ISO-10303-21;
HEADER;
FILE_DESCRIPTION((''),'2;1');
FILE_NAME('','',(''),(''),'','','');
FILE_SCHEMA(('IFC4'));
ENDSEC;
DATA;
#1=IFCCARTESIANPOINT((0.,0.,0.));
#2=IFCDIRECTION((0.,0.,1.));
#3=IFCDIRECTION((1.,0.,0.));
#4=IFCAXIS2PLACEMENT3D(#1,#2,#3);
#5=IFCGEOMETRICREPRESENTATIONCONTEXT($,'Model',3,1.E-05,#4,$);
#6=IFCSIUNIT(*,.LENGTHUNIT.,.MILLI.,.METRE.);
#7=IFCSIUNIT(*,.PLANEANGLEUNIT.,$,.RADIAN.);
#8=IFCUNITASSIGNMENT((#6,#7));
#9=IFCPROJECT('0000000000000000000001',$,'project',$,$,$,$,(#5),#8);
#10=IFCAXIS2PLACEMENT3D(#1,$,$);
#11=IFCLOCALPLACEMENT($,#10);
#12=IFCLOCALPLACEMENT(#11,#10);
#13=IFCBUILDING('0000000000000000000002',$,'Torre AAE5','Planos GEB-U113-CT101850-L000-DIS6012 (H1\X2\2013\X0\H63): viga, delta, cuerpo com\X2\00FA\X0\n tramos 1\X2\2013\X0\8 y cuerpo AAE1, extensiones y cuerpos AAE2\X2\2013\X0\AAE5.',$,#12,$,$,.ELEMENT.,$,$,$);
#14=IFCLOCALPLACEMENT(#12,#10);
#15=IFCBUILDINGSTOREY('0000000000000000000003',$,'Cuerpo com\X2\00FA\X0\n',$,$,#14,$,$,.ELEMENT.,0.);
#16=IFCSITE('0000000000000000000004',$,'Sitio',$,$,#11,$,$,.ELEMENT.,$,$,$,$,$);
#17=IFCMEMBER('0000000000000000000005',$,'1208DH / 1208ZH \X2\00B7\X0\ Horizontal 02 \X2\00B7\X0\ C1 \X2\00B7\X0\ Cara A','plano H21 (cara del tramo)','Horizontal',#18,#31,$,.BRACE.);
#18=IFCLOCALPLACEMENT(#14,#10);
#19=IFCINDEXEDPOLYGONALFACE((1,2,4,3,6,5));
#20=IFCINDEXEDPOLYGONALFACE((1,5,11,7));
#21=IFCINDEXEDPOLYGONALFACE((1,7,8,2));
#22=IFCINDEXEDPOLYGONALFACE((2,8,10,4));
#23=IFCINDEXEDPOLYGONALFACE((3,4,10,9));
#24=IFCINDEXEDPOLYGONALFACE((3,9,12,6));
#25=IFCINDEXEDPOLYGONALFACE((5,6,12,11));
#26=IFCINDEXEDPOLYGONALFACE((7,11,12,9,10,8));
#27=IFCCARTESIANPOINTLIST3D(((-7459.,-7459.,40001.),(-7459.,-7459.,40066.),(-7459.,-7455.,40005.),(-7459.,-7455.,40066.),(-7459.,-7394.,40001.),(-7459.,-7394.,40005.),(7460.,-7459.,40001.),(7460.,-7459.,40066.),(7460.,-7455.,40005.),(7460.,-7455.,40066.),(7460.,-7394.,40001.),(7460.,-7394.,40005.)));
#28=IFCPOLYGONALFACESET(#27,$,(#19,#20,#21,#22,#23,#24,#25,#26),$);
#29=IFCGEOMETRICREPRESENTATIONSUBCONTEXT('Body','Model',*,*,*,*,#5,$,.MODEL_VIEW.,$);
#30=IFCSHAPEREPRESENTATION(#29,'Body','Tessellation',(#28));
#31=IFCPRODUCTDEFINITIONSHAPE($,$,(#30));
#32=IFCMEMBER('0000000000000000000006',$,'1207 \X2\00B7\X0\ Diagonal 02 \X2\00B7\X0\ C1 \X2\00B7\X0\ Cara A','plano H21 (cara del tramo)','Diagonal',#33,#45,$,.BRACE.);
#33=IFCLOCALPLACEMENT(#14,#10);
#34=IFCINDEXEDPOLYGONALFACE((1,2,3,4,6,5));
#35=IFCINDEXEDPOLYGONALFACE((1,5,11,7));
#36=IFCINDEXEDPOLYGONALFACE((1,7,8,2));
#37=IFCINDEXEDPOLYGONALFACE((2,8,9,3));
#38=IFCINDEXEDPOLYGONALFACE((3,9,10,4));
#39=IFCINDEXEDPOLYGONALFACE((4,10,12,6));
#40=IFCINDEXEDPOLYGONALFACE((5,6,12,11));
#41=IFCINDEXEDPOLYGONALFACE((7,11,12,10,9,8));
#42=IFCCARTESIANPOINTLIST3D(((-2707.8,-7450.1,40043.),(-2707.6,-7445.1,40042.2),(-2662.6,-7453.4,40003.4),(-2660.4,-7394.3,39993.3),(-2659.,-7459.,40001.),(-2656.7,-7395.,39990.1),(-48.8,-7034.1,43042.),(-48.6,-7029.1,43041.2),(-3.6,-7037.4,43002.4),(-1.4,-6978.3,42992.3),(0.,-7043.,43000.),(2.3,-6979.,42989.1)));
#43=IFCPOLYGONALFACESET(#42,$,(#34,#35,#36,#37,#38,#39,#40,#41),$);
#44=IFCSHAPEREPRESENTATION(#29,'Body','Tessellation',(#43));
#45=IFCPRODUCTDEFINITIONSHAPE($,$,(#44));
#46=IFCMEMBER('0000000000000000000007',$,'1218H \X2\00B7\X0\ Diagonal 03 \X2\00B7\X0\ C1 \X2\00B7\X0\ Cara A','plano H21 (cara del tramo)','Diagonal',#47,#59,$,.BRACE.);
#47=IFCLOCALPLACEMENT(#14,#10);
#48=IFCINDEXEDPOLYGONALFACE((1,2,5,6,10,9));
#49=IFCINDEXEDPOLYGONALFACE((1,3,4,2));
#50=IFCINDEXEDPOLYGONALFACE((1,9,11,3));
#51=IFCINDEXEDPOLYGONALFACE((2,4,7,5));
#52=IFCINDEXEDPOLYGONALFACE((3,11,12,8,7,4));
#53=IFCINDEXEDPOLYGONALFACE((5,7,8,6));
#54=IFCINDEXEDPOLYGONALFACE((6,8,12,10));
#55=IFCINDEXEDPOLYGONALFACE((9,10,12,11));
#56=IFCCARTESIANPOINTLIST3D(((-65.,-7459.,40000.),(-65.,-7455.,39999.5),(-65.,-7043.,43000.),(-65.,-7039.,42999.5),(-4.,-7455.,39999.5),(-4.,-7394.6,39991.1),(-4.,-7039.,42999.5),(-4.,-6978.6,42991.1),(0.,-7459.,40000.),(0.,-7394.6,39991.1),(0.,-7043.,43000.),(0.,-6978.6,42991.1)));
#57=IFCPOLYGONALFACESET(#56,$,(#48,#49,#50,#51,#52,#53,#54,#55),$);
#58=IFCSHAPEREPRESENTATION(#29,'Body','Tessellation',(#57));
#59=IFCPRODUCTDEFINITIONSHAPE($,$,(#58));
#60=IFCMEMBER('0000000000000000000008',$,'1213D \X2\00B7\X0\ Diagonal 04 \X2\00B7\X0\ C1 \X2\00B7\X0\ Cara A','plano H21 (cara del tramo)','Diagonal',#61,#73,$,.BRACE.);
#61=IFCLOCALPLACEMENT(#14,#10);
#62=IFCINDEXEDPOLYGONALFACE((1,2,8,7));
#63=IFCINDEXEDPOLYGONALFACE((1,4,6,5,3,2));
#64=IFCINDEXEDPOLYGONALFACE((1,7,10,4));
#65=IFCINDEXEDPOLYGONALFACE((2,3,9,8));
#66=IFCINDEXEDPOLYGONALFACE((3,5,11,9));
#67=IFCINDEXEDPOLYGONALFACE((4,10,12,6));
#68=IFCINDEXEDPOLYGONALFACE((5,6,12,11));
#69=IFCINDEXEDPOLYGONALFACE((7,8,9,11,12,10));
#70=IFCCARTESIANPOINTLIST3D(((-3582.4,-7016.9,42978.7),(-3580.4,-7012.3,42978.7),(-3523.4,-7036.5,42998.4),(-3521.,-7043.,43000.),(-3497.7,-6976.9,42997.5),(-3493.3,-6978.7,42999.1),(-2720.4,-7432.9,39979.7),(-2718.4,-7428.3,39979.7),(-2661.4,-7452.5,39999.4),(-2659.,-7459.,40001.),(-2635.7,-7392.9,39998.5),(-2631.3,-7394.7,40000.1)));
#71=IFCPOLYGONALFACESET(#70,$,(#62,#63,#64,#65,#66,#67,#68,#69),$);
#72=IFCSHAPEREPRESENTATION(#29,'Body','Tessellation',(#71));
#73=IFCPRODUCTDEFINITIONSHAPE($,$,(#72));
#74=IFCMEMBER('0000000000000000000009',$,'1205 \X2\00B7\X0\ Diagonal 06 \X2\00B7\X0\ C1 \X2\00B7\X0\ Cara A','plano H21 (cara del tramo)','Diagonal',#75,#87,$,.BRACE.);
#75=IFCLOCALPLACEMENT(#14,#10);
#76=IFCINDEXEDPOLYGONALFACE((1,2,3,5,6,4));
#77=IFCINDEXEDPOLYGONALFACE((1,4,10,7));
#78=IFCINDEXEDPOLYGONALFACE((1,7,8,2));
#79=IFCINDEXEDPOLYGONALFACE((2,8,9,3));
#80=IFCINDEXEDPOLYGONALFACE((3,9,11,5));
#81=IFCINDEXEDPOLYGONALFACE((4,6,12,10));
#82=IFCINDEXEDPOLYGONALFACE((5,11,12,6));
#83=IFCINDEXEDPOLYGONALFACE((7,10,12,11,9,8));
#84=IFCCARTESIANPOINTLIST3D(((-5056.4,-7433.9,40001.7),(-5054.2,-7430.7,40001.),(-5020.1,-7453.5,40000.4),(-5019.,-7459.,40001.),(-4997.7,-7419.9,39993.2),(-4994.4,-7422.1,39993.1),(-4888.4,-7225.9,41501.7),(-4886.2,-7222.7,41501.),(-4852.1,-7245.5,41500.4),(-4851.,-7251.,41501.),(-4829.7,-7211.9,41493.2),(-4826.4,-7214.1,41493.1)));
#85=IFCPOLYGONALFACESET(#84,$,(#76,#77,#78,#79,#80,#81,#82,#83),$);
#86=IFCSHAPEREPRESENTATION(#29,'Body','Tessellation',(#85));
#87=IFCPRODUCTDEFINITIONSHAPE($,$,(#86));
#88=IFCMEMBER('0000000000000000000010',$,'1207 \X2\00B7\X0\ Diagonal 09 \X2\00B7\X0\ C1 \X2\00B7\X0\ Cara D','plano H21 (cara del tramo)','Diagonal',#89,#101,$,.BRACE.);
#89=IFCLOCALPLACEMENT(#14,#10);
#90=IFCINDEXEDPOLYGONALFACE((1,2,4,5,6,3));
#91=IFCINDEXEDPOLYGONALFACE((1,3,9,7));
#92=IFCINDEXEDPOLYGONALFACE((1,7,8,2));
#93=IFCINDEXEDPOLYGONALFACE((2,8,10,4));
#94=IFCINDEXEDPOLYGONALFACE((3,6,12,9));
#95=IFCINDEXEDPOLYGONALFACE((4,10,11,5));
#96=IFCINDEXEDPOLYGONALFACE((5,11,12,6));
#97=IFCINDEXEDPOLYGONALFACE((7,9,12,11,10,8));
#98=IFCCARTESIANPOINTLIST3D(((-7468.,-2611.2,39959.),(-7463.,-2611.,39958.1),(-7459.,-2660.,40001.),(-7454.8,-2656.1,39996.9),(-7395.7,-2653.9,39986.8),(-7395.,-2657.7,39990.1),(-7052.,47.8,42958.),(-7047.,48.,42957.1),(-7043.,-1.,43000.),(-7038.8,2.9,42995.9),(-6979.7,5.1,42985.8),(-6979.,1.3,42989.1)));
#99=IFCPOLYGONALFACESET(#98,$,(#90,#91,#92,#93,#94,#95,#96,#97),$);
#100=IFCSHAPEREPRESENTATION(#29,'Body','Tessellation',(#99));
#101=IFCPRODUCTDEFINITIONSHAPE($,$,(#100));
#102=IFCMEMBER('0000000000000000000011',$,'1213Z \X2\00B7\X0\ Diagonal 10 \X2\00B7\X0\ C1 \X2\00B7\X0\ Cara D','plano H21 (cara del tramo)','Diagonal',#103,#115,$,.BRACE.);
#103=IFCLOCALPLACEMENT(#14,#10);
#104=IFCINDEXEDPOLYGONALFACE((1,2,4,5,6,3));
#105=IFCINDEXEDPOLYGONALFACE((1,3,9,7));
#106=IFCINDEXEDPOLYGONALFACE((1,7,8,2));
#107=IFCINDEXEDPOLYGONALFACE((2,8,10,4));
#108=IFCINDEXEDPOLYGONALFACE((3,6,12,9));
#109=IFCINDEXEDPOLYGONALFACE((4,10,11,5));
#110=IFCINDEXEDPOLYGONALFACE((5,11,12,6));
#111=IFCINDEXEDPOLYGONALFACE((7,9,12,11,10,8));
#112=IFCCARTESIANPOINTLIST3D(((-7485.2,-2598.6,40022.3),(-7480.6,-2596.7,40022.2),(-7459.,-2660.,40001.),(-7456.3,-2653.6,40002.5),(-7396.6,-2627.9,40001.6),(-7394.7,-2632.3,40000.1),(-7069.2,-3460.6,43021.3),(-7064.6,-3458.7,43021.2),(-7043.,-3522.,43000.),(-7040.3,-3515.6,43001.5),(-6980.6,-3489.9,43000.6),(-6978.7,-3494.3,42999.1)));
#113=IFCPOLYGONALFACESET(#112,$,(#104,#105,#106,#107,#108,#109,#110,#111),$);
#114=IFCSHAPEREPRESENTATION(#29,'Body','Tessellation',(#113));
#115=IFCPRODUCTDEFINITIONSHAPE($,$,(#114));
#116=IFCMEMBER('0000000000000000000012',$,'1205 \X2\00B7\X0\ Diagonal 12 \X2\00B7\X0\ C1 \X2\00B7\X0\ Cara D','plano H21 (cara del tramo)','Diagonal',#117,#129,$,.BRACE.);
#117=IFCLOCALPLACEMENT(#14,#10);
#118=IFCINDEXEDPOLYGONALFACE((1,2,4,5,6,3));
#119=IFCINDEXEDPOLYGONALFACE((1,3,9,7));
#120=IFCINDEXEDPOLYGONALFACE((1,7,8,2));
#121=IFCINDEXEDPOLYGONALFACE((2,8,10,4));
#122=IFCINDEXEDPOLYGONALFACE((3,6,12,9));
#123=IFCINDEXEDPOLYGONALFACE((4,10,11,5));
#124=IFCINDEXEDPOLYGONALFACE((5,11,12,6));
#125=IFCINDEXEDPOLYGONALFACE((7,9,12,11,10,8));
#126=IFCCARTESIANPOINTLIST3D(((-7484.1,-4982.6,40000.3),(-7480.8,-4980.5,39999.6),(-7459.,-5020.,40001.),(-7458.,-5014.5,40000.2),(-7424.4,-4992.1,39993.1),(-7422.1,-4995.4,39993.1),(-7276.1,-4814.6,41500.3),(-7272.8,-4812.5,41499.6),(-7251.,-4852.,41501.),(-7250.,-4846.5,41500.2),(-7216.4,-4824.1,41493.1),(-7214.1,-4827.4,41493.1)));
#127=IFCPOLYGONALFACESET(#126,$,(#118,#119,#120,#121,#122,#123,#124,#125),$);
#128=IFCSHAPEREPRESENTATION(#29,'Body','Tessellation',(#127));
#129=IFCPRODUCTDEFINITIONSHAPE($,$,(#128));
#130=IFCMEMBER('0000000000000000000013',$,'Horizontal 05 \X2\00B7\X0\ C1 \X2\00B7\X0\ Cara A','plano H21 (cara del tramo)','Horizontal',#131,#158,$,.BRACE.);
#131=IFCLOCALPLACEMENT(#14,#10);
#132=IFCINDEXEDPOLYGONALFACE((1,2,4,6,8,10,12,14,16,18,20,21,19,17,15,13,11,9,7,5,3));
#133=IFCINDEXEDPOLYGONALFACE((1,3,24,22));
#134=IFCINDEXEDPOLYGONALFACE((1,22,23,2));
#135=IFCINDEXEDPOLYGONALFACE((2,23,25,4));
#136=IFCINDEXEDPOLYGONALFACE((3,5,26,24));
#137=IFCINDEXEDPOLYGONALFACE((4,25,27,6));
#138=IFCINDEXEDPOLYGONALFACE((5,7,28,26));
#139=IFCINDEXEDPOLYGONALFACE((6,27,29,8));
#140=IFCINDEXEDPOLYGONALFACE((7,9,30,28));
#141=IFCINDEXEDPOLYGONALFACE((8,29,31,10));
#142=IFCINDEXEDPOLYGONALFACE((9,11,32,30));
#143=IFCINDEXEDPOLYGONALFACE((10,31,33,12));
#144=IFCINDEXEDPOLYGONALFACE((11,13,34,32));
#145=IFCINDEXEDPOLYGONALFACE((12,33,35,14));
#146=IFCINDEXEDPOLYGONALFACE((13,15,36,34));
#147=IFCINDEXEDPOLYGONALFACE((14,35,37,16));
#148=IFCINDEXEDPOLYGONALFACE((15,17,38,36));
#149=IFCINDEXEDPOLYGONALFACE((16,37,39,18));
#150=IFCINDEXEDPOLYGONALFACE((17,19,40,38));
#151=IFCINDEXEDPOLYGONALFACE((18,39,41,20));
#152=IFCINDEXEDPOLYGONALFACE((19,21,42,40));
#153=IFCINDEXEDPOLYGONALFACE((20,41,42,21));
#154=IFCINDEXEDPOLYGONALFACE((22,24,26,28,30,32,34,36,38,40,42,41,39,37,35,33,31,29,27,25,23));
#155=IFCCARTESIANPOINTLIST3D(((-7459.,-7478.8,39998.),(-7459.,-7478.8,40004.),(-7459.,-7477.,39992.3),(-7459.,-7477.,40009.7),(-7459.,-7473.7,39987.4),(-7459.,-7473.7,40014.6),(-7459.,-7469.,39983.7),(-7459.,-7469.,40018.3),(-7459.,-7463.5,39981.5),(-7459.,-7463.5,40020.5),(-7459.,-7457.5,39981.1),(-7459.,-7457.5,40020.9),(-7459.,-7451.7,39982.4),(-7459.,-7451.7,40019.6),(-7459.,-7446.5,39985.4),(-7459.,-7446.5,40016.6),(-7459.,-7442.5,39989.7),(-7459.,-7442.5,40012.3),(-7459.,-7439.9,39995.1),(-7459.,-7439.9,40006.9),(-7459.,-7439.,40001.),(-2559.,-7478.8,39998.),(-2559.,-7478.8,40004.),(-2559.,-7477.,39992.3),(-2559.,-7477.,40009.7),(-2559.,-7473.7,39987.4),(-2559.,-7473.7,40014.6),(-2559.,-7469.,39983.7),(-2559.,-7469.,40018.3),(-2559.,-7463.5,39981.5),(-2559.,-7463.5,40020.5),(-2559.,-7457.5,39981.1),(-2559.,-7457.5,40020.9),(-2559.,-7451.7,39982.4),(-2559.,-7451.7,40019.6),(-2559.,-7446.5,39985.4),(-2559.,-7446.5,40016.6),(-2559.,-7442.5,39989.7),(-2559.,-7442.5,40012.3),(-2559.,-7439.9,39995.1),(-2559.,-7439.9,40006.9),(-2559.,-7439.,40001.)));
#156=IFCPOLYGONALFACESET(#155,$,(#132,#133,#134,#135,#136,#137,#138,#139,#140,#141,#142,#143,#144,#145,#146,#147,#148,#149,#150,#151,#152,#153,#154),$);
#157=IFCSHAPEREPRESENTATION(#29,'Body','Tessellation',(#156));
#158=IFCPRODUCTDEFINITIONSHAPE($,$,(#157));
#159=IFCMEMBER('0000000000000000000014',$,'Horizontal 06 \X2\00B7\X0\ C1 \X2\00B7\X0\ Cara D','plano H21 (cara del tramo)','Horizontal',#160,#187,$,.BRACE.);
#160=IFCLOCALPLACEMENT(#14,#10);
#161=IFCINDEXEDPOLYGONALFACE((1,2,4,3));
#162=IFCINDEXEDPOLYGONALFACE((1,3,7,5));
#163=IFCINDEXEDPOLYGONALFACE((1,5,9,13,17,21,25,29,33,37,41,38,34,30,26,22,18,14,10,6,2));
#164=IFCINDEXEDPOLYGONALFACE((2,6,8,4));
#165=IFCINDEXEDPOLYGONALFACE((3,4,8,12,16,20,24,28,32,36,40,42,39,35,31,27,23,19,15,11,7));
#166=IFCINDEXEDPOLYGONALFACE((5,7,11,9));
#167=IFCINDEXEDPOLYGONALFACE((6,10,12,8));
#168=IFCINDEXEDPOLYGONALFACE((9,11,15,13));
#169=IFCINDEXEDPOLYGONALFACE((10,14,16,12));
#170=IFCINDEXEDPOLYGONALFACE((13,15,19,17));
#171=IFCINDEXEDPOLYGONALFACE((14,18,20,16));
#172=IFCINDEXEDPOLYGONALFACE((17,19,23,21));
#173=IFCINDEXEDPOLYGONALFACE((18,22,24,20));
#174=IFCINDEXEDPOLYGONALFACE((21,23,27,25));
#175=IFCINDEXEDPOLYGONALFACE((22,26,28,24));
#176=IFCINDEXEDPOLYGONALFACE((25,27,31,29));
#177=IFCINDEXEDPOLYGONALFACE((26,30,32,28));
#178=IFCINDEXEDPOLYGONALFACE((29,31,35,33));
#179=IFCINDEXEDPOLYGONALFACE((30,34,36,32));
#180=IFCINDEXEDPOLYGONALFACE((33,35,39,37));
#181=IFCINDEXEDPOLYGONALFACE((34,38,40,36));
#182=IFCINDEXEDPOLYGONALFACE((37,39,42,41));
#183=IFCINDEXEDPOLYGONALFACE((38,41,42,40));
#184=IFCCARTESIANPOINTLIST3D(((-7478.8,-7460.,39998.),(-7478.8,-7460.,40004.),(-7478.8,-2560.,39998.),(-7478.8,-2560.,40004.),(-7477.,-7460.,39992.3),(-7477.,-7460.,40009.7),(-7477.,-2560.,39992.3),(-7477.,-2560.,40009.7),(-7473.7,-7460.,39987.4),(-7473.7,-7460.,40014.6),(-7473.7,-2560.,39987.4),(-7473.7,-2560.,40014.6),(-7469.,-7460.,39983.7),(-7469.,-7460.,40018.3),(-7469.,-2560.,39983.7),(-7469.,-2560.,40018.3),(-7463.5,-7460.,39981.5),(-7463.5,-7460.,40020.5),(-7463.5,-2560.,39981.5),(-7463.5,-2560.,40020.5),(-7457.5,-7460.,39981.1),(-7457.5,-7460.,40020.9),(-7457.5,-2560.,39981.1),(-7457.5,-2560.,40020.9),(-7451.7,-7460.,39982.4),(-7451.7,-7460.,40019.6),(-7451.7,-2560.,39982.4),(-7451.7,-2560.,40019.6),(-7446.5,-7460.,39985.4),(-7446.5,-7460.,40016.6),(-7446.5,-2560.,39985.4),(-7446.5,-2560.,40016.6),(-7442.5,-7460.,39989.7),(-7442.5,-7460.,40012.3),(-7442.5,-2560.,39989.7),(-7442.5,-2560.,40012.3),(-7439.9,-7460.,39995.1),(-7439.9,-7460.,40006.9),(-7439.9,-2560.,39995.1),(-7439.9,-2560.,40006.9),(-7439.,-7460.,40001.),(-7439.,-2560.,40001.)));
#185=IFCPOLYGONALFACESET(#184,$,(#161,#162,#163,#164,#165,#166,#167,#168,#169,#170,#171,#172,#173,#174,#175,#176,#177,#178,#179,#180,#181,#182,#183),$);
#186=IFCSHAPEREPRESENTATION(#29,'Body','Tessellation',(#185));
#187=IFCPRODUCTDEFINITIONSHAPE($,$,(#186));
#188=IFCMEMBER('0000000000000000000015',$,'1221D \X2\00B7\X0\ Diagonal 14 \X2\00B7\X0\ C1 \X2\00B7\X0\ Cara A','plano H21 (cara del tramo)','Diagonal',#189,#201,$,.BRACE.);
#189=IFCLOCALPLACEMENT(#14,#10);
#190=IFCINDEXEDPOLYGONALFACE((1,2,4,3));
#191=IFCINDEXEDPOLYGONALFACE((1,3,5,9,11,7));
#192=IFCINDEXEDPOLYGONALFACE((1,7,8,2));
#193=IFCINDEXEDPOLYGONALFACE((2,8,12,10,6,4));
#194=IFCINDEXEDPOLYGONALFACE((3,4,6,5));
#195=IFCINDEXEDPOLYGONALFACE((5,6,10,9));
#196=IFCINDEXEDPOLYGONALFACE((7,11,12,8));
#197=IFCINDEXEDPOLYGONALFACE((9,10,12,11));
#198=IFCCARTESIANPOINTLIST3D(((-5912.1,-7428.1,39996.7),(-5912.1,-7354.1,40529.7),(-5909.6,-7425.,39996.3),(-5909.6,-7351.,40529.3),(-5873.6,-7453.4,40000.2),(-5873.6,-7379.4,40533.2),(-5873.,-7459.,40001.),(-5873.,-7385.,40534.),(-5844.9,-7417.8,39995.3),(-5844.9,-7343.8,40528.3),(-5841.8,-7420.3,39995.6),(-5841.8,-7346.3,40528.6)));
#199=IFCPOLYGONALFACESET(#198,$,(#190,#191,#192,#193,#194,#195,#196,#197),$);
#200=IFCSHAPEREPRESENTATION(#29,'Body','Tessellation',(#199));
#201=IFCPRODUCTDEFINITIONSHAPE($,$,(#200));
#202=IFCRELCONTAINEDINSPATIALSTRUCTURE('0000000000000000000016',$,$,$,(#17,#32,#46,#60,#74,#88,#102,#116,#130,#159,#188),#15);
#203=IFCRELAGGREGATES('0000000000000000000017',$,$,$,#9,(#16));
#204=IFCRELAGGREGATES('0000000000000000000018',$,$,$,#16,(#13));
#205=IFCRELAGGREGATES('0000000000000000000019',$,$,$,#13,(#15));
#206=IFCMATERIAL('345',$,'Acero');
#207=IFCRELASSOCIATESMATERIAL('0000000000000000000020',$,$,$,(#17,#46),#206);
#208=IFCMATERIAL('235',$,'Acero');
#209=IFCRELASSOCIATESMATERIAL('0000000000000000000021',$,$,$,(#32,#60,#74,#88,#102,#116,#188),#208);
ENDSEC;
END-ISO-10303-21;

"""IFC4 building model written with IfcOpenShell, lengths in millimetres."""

from ifc_helpers import new_model, si_unit, frame, frame_2d, origin, origin_with_axes, place, context, subcontext, project, spatial, circle, l_section, extrude, material, element, save


model = new_model("IFC4")

# Units and contexts
model_context = context("Model", 3, precision=1e-05, world=origin_with_axes())
body_context = subcontext(model_context, "Body", "Model", "MODEL_VIEW")
ifc_project = project(units=[si_unit("LENGTHUNIT", "METRE", prefix="MILLI"), si_unit("PLANEANGLEUNIT", "RADIAN")], contexts=[model_context])

# Site, building, storey
site_placement = place(None, origin())
site = spatial("IfcSite", under=ifc_project, at=site_placement, Name="Sitio", CompositionType="ELEMENT")
building_placement = place(site_placement, origin())
building = spatial("IfcBuilding", under=site, at=building_placement, Name="Torre AAE5", Description="Planos GEB-U113-CT101850-L000-DIS6012 (H1–H63): viga, delta, cuerpo común tramos 1–8 y cuerpo AAE1, extensiones y cuerpos AAE2–AAE5.", CompositionType="ELEMENT")
storey_placement = place(building_placement, origin())
storey = spatial("IfcBuildingStorey", under=building, at=storey_placement, Name="Cuerpo común", CompositionType="ELEMENT", Elevation=0.0)

# Members
ifc_material_1 = material(Name="345", Category="Acero")
member_1_placement = place(storey_placement, frame((-7459.0, -7459.0, 40001.0), z_axis=(1.0, 0.0, 0.0), x_axis=(0.0, 1.0, 0.0)))
element("IfcMember", 1, at=member_1_placement, inside=storey, material=ifc_material_1, Name="1208DH / 1208ZH · Horizontal 02 · C1 · Cara A", Description="plano H21 (cara del tramo)", ObjectType="Horizontal", PredefinedType="BRACE", context=body_context, shape_type="SweptSolid", body=[
    extrude(l_section(Depth=65.0, Width=65.0, Thickness=4.0, at=frame_2d((32.5, 32.5))), None, (0.0, 0.0, 1.0), 14919.0),
])
ifc_material_2 = material(Name="235", Category="Acero")
member_2_placement = place(storey_placement, frame((-2659.0, -7459.0, 40001.0), z_axis=(0.659874, 0.103237, 0.74425), x_axis=(0.035691, 0.985091, -0.168289)))
element("IfcMember", 2, at=member_2_placement, inside=storey, material=ifc_material_2, Name="1207 · Diagonal 02 · C1 · Cara A", Description="plano H21 (cara del tramo)", ObjectType="Diagonal", PredefinedType="BRACE", context=body_context, shape_type="SweptSolid", body=[
    extrude(l_section(Depth=65.0, Width=65.0, Thickness=5.0, at=frame_2d((32.5, 32.5))), None, (0.0, 0.0, 1.0), 4029.6),
])
member_3_placement = place(storey_placement, frame((0.0, -7459.0, 40000.0), z_axis=(0.0, 0.137352, 0.990522), x_axis=(0.0, 0.990522, -0.137352)))
element("IfcMember", 3, at=member_3_placement, inside=storey, material=ifc_material_1, Name="1218H · Diagonal 03 · C1 · Cara A", Description="plano H21 (cara del tramo)", ObjectType="Diagonal", PredefinedType="BRACE", context=body_context, shape_type="SweptSolid", body=[
    extrude(l_section(Depth=65.0, Width=65.0, Thickness=4.0, at=frame_2d((32.5, 32.5))), None, (0.0, 0.0, 1.0), 3028.7),
])
member_4_placement = place(storey_placement, frame((-2659.0, -7459.0, 40001.0), z_axis=(-0.273822, 0.132146, 0.952659), x_axis=(0.395969, 0.918164, -0.013548)))
element("IfcMember", 4, at=member_4_placement, inside=storey, material=ifc_material_2, Name="1213D · Diagonal 04 · C1 · Cara A", Description="plano H21 (cara del tramo)", ObjectType="Diagonal", PredefinedType="BRACE", context=body_context, shape_type="SweptSolid", body=[
    extrude(l_section(Depth=70.0, Width=70.0, Thickness=5.0, at=frame_2d((35.0, 35.0))), None, (0.0, 0.0, 1.0), 3148.0),
])
member_5_placement = place(storey_placement, frame((-5019.0, -7459.0, 40001.0), z_axis=(0.110262, 0.136515, 0.984483), x_axis=(0.54631, 0.819145, -0.174775)))
element("IfcMember", 5, at=member_5_placement, inside=storey, material=ifc_material_2, Name="1205 · Diagonal 06 · C1 · Cara A", Description="plano H21 (cara del tramo)", ObjectType="Diagonal", PredefinedType="BRACE", context=body_context, shape_type="SweptSolid", body=[
    extrude(l_section(Depth=45.0, Width=45.0, Thickness=4.0, at=frame_2d((22.5, 22.5))), None, (0.0, 0.0, 1.0), 1523.6),
])
member_6_placement = place(storey_placement, frame((-7459.0, -2660.0, 40001.0), z_axis=(0.103237, 0.659874, 0.74425), x_axis=(0.985077, 0.035769, -0.168357)))
element("IfcMember", 6, at=member_6_placement, inside=storey, material=ifc_material_2, Name="1207 · Diagonal 09 · C1 · Cara D", Description="plano H21 (cara del tramo)", ObjectType="Diagonal", PredefinedType="BRACE", context=body_context, shape_type="SweptSolid", body=[
    extrude(l_section(Depth=65.0, Width=65.0, Thickness=5.0, at=frame_2d((32.5, 32.5))), None, (0.0, 0.0, 1.0), 4029.6),
])
member_7_placement = place(storey_placement, frame((-7459.0, -2660.0, 40001.0), z_axis=(0.132146, -0.273822, 0.952659), x_axis=(0.918122, 0.396066, -0.013514)))
element("IfcMember", 7, at=member_7_placement, inside=storey, material=ifc_material_2, Name="1213Z · Diagonal 10 · C1 · Cara D", Description="plano H21 (cara del tramo)", ObjectType="Diagonal", PredefinedType="BRACE", context=body_context, shape_type="SweptSolid", body=[
    extrude(l_section(Depth=70.0, Width=70.0, Thickness=5.0, at=frame_2d((35.0, 35.0))), None, (0.0, 0.0, 1.0), 3148.0),
])
member_8_placement = place(storey_placement, frame((-7459.0, -5020.0, 40001.0), z_axis=(0.136515, 0.110262, 0.984483), x_axis=(0.819092, 0.546389, -0.174776)))
element("IfcMember", 8, at=member_8_placement, inside=storey, material=ifc_material_2, Name="1205 · Diagonal 12 · C1 · Cara D", Description="plano H21 (cara del tramo)", ObjectType="Diagonal", PredefinedType="BRACE", context=body_context, shape_type="SweptSolid", body=[
    extrude(l_section(Depth=45.0, Width=45.0, Thickness=4.0, at=frame_2d((22.5, 22.5))), None, (0.0, 0.0, 1.0), 1523.6),
])
for number, where, z_axis, x_axis, name in (
    (9, (-7459.0, -7459.0, 40001.0), (1.0, 0.0, 0.0), (0.0, 1.0, 0.0), "Horizontal 05 · C1 · Cara A"),
    (10, (-7459.0, -7460.0, 40001.0), (0.0, 1.0, 0.0), (1.0, 0.0, 0.0), "Horizontal 06 · C1 · Cara D"),
):
    element("IfcMember", number, at=place(storey_placement, frame(where, z_axis=z_axis, x_axis=x_axis)), inside=storey, Name=name, Description="plano H21 (cara del tramo)", ObjectType="Horizontal", PredefinedType="BRACE", context=body_context, shape_type="SweptSolid", body=[
        extrude(circle(Radius=20.0), None, (0.0, 0.0, 1.0), 4900.0),
    ])
member_9_placement = place(storey_placement, frame((-5873.0, -7459.0, 40001.0), z_axis=(0.0, 0.137518, 0.990499), x_axis=(0.624164, 0.77387, -0.107442)))
element("IfcMember", 11, at=member_9_placement, inside=storey, material=ifc_material_2, Name="1221D · Diagonal 14 · C1 · Cara A", Description="plano H21 (cara del tramo)", ObjectType="Diagonal", PredefinedType="BRACE", context=body_context, shape_type="SweptSolid", body=[
    extrude(l_section(Depth=50.0, Width=50.0, Thickness=4.0, at=frame_2d((25.0, 25.0))), None, (0.0, 0.0, 1.0), 538.1),
])

save(model, "model.ifc")
